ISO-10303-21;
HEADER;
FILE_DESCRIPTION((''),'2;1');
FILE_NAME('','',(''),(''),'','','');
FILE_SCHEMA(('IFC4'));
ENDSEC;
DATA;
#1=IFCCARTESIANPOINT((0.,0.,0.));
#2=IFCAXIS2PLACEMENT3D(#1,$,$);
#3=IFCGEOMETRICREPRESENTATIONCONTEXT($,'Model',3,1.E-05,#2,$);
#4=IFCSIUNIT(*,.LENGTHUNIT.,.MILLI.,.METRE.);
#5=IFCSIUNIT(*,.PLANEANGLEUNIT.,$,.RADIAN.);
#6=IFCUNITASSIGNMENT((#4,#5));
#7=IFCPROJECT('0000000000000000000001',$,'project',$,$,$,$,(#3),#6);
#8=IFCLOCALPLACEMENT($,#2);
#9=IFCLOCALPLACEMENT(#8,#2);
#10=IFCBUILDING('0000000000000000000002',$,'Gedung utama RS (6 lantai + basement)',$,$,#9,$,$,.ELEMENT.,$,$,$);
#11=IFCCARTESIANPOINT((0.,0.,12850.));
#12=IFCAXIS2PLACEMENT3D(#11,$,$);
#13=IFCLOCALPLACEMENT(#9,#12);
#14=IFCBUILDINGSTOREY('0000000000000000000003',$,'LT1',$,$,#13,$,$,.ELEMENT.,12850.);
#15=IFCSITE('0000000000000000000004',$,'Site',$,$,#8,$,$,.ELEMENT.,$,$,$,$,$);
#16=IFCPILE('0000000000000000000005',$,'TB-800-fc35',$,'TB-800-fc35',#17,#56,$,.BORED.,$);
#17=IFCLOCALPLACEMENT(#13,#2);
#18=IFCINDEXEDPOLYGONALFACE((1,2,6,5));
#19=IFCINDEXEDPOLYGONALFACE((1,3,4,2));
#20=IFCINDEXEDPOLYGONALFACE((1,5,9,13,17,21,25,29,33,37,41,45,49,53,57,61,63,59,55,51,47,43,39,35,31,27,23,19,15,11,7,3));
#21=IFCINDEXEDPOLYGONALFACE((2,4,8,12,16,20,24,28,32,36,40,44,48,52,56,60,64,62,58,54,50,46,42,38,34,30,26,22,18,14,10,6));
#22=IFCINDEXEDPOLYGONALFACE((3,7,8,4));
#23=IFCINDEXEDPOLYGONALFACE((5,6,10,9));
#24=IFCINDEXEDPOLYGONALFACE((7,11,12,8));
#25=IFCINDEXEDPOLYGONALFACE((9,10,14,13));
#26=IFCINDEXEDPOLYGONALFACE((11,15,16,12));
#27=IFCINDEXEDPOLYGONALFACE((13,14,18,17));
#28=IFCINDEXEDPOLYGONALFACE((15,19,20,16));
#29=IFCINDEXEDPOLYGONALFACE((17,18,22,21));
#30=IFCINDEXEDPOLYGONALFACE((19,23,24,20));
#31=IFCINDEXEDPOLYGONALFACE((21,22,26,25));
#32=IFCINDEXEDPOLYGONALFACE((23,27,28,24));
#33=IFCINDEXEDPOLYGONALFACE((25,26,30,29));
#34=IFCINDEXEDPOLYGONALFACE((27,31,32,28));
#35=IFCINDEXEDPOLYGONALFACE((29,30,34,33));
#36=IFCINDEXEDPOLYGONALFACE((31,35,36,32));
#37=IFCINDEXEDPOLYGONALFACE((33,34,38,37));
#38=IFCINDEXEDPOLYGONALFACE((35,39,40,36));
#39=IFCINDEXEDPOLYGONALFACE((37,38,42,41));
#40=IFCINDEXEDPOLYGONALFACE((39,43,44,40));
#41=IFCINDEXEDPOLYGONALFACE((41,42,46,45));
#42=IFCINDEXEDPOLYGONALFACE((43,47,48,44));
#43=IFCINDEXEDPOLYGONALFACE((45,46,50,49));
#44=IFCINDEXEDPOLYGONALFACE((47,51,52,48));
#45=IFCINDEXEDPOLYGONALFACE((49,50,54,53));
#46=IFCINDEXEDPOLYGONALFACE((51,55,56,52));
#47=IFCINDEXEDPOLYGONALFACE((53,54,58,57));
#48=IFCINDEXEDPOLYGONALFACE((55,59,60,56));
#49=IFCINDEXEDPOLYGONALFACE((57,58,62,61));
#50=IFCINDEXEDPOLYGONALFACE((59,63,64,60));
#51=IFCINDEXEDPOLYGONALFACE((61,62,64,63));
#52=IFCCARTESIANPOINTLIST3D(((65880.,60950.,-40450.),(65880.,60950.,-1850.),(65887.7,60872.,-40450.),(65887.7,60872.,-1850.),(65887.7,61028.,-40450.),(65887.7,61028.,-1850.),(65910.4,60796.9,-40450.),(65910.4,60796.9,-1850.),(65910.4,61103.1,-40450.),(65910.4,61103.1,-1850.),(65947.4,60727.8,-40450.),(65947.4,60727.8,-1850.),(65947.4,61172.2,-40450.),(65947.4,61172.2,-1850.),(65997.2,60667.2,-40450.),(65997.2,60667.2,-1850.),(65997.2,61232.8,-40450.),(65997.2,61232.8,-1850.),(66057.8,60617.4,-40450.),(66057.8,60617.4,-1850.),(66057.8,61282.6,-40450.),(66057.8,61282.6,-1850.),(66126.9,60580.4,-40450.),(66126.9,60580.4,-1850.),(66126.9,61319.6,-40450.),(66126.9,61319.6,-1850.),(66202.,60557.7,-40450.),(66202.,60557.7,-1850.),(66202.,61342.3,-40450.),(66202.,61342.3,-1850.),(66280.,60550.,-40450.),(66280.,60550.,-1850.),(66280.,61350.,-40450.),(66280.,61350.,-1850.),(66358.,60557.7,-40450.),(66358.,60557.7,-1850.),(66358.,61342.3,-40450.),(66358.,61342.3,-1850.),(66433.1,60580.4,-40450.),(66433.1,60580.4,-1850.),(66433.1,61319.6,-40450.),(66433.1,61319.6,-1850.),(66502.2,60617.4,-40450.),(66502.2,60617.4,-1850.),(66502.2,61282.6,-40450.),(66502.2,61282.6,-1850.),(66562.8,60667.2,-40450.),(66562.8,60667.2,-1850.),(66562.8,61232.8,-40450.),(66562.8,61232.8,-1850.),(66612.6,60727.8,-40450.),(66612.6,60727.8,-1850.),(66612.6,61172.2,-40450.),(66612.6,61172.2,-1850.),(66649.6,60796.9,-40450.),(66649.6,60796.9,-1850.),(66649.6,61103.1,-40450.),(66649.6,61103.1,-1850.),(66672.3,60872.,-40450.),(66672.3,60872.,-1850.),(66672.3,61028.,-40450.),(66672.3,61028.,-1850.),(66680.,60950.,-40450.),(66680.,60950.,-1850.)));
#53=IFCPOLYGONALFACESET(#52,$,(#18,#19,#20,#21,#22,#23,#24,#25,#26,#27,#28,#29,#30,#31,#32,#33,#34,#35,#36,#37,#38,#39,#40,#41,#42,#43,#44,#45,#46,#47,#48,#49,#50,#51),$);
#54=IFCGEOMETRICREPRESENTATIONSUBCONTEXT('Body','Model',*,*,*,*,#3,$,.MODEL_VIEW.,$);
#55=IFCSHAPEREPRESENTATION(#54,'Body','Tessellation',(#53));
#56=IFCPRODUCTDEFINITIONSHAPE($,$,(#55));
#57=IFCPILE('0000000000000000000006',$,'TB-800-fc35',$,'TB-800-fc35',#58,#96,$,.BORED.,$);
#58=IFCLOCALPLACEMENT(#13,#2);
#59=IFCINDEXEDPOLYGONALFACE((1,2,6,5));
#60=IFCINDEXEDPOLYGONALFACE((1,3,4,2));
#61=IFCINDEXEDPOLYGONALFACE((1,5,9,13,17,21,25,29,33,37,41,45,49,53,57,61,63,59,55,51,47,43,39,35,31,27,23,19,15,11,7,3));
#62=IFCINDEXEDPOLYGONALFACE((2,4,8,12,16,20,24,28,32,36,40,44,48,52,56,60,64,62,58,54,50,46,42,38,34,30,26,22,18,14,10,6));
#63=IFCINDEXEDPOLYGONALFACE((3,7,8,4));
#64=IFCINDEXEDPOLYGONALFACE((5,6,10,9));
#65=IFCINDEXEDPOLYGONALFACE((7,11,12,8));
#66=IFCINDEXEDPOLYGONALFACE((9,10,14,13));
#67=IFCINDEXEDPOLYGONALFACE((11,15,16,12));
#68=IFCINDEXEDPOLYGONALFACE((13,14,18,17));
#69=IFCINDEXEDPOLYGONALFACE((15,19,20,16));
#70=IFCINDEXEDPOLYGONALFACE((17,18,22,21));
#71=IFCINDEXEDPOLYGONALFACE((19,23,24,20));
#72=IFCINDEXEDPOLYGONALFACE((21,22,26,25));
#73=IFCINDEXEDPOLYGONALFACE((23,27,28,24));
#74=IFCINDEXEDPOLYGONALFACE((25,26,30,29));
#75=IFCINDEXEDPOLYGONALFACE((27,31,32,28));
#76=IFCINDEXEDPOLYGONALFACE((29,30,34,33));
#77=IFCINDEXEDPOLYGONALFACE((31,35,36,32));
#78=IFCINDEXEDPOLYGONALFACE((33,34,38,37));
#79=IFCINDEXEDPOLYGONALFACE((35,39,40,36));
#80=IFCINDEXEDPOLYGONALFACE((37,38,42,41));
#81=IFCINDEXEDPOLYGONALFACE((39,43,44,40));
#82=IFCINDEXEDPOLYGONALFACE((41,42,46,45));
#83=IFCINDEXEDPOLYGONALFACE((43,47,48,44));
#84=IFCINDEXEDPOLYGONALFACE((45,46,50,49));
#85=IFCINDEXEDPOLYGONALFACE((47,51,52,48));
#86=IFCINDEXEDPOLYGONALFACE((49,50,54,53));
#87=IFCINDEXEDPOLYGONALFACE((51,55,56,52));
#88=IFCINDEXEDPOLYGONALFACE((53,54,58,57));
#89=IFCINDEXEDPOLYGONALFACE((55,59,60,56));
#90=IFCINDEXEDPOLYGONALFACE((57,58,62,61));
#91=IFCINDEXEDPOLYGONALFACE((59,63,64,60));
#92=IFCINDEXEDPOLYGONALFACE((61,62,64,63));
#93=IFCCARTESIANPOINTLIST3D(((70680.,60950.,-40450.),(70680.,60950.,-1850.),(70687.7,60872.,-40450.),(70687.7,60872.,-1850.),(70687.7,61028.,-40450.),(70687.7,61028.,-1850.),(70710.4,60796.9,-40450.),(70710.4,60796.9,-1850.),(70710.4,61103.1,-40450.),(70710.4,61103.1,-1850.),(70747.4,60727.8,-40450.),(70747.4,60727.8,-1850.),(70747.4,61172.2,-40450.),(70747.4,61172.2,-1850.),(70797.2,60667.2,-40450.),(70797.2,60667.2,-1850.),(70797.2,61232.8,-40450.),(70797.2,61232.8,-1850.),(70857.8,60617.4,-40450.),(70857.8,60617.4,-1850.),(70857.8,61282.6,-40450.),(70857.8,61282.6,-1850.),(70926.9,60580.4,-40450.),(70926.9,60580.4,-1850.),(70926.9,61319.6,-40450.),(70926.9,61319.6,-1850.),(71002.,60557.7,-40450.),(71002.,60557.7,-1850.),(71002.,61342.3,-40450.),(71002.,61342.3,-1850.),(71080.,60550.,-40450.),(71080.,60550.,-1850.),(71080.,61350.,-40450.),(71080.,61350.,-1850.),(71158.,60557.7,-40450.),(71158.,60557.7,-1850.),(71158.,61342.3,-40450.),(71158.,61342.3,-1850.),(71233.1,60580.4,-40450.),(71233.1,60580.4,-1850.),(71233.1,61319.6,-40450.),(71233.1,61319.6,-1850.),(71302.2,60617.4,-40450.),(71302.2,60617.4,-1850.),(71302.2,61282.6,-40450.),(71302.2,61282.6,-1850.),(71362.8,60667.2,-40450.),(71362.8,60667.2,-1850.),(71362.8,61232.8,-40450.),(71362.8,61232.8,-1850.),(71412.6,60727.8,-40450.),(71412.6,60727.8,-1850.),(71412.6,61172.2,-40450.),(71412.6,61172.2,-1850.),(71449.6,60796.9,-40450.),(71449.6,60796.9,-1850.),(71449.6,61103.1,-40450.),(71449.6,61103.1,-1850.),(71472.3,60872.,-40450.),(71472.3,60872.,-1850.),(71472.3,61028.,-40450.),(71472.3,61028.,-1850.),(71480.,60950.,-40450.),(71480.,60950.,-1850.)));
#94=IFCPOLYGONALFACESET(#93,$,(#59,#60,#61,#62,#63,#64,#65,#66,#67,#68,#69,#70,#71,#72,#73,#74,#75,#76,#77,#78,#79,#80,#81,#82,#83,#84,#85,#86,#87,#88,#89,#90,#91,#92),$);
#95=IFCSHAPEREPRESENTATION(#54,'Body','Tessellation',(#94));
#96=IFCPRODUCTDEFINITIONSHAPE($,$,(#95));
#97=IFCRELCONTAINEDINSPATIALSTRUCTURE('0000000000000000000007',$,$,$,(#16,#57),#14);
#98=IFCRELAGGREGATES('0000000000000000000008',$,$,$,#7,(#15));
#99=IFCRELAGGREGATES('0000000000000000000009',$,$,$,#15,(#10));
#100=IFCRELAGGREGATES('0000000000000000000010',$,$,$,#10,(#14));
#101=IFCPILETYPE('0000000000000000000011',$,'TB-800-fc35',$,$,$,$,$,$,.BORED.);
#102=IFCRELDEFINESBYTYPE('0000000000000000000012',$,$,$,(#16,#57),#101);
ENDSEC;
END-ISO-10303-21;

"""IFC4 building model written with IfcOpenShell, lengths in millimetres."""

from ifc_helpers import new_model, si_unit, frame, origin, origin_2d, place, context, subcontext, project, spatial, circle, extrude, material_profile, profile_set, profile_usage, type_object, element, save


model = new_model("IFC4")

# Units and contexts
model_context = context("Model", 3, precision=1e-05, world=origin())
body_context = subcontext(model_context, "Body", "Model", "MODEL_VIEW")
ifc_project = project(units=[si_unit("LENGTHUNIT", "METRE", prefix="MILLI"), si_unit("PLANEANGLEUNIT", "RADIAN")], contexts=[model_context])

# Site, building, storey
site_placement = place(None, origin())
site = spatial("IfcSite", under=ifc_project, at=site_placement, Name="Site", CompositionType="ELEMENT")
building_placement = place(site_placement, origin())
building = spatial("IfcBuilding", under=site, at=building_placement, Name="Gedung utama RS (6 lantai + basement)", CompositionType="ELEMENT")
storey_placement = place(building_placement, frame((0.0, 0.0, 12850.0)))
storey = spatial("IfcBuildingStorey", under=building, at=storey_placement, Name="LT1", CompositionType="ELEMENT", Elevation=12850.0)

# Piles
ifc_material_profile = material_profile(None, circle(Radius=400.0, at=origin_2d()), Name="TB-800-fc35")
ifc_profile_set = profile_set([ifc_material_profile], Name="TB-800-fc35")
ifc_profile_usage = profile_usage(ifc_profile_set, cardinal=5)
pile_type = type_object("IfcPileType", Name="TB-800-fc35", PredefinedType="BORED", material=ifc_profile_set)
for number, where, z_axis, x_axis, name in (
    (1, (66280.0, 60950.0, -40450.0), (0.0, 0.0, 1.0), (1.0, 0.0, 0.0), "TB-800-fc35"),
    (2, (71080.0, 60950.0, -40450.0), (0.0, 0.0, 1.0), (1.0, 0.0, 0.0), "TB-800-fc35"),
):
    element("IfcPile", number, at=place(storey_placement, frame(where, z_axis=z_axis, x_axis=x_axis)), inside=storey, type_object=pile_type, material=ifc_profile_usage, Name=name, ObjectType="TB-800-fc35", PredefinedType="BORED", context=body_context, shape_type="SweptSolid", body=[
        extrude(circle(Radius=400.0, at=origin_2d()), origin(), (0.0, 0.0, 1.0), 38600.0),
    ])

save(model, "model.ifc")
